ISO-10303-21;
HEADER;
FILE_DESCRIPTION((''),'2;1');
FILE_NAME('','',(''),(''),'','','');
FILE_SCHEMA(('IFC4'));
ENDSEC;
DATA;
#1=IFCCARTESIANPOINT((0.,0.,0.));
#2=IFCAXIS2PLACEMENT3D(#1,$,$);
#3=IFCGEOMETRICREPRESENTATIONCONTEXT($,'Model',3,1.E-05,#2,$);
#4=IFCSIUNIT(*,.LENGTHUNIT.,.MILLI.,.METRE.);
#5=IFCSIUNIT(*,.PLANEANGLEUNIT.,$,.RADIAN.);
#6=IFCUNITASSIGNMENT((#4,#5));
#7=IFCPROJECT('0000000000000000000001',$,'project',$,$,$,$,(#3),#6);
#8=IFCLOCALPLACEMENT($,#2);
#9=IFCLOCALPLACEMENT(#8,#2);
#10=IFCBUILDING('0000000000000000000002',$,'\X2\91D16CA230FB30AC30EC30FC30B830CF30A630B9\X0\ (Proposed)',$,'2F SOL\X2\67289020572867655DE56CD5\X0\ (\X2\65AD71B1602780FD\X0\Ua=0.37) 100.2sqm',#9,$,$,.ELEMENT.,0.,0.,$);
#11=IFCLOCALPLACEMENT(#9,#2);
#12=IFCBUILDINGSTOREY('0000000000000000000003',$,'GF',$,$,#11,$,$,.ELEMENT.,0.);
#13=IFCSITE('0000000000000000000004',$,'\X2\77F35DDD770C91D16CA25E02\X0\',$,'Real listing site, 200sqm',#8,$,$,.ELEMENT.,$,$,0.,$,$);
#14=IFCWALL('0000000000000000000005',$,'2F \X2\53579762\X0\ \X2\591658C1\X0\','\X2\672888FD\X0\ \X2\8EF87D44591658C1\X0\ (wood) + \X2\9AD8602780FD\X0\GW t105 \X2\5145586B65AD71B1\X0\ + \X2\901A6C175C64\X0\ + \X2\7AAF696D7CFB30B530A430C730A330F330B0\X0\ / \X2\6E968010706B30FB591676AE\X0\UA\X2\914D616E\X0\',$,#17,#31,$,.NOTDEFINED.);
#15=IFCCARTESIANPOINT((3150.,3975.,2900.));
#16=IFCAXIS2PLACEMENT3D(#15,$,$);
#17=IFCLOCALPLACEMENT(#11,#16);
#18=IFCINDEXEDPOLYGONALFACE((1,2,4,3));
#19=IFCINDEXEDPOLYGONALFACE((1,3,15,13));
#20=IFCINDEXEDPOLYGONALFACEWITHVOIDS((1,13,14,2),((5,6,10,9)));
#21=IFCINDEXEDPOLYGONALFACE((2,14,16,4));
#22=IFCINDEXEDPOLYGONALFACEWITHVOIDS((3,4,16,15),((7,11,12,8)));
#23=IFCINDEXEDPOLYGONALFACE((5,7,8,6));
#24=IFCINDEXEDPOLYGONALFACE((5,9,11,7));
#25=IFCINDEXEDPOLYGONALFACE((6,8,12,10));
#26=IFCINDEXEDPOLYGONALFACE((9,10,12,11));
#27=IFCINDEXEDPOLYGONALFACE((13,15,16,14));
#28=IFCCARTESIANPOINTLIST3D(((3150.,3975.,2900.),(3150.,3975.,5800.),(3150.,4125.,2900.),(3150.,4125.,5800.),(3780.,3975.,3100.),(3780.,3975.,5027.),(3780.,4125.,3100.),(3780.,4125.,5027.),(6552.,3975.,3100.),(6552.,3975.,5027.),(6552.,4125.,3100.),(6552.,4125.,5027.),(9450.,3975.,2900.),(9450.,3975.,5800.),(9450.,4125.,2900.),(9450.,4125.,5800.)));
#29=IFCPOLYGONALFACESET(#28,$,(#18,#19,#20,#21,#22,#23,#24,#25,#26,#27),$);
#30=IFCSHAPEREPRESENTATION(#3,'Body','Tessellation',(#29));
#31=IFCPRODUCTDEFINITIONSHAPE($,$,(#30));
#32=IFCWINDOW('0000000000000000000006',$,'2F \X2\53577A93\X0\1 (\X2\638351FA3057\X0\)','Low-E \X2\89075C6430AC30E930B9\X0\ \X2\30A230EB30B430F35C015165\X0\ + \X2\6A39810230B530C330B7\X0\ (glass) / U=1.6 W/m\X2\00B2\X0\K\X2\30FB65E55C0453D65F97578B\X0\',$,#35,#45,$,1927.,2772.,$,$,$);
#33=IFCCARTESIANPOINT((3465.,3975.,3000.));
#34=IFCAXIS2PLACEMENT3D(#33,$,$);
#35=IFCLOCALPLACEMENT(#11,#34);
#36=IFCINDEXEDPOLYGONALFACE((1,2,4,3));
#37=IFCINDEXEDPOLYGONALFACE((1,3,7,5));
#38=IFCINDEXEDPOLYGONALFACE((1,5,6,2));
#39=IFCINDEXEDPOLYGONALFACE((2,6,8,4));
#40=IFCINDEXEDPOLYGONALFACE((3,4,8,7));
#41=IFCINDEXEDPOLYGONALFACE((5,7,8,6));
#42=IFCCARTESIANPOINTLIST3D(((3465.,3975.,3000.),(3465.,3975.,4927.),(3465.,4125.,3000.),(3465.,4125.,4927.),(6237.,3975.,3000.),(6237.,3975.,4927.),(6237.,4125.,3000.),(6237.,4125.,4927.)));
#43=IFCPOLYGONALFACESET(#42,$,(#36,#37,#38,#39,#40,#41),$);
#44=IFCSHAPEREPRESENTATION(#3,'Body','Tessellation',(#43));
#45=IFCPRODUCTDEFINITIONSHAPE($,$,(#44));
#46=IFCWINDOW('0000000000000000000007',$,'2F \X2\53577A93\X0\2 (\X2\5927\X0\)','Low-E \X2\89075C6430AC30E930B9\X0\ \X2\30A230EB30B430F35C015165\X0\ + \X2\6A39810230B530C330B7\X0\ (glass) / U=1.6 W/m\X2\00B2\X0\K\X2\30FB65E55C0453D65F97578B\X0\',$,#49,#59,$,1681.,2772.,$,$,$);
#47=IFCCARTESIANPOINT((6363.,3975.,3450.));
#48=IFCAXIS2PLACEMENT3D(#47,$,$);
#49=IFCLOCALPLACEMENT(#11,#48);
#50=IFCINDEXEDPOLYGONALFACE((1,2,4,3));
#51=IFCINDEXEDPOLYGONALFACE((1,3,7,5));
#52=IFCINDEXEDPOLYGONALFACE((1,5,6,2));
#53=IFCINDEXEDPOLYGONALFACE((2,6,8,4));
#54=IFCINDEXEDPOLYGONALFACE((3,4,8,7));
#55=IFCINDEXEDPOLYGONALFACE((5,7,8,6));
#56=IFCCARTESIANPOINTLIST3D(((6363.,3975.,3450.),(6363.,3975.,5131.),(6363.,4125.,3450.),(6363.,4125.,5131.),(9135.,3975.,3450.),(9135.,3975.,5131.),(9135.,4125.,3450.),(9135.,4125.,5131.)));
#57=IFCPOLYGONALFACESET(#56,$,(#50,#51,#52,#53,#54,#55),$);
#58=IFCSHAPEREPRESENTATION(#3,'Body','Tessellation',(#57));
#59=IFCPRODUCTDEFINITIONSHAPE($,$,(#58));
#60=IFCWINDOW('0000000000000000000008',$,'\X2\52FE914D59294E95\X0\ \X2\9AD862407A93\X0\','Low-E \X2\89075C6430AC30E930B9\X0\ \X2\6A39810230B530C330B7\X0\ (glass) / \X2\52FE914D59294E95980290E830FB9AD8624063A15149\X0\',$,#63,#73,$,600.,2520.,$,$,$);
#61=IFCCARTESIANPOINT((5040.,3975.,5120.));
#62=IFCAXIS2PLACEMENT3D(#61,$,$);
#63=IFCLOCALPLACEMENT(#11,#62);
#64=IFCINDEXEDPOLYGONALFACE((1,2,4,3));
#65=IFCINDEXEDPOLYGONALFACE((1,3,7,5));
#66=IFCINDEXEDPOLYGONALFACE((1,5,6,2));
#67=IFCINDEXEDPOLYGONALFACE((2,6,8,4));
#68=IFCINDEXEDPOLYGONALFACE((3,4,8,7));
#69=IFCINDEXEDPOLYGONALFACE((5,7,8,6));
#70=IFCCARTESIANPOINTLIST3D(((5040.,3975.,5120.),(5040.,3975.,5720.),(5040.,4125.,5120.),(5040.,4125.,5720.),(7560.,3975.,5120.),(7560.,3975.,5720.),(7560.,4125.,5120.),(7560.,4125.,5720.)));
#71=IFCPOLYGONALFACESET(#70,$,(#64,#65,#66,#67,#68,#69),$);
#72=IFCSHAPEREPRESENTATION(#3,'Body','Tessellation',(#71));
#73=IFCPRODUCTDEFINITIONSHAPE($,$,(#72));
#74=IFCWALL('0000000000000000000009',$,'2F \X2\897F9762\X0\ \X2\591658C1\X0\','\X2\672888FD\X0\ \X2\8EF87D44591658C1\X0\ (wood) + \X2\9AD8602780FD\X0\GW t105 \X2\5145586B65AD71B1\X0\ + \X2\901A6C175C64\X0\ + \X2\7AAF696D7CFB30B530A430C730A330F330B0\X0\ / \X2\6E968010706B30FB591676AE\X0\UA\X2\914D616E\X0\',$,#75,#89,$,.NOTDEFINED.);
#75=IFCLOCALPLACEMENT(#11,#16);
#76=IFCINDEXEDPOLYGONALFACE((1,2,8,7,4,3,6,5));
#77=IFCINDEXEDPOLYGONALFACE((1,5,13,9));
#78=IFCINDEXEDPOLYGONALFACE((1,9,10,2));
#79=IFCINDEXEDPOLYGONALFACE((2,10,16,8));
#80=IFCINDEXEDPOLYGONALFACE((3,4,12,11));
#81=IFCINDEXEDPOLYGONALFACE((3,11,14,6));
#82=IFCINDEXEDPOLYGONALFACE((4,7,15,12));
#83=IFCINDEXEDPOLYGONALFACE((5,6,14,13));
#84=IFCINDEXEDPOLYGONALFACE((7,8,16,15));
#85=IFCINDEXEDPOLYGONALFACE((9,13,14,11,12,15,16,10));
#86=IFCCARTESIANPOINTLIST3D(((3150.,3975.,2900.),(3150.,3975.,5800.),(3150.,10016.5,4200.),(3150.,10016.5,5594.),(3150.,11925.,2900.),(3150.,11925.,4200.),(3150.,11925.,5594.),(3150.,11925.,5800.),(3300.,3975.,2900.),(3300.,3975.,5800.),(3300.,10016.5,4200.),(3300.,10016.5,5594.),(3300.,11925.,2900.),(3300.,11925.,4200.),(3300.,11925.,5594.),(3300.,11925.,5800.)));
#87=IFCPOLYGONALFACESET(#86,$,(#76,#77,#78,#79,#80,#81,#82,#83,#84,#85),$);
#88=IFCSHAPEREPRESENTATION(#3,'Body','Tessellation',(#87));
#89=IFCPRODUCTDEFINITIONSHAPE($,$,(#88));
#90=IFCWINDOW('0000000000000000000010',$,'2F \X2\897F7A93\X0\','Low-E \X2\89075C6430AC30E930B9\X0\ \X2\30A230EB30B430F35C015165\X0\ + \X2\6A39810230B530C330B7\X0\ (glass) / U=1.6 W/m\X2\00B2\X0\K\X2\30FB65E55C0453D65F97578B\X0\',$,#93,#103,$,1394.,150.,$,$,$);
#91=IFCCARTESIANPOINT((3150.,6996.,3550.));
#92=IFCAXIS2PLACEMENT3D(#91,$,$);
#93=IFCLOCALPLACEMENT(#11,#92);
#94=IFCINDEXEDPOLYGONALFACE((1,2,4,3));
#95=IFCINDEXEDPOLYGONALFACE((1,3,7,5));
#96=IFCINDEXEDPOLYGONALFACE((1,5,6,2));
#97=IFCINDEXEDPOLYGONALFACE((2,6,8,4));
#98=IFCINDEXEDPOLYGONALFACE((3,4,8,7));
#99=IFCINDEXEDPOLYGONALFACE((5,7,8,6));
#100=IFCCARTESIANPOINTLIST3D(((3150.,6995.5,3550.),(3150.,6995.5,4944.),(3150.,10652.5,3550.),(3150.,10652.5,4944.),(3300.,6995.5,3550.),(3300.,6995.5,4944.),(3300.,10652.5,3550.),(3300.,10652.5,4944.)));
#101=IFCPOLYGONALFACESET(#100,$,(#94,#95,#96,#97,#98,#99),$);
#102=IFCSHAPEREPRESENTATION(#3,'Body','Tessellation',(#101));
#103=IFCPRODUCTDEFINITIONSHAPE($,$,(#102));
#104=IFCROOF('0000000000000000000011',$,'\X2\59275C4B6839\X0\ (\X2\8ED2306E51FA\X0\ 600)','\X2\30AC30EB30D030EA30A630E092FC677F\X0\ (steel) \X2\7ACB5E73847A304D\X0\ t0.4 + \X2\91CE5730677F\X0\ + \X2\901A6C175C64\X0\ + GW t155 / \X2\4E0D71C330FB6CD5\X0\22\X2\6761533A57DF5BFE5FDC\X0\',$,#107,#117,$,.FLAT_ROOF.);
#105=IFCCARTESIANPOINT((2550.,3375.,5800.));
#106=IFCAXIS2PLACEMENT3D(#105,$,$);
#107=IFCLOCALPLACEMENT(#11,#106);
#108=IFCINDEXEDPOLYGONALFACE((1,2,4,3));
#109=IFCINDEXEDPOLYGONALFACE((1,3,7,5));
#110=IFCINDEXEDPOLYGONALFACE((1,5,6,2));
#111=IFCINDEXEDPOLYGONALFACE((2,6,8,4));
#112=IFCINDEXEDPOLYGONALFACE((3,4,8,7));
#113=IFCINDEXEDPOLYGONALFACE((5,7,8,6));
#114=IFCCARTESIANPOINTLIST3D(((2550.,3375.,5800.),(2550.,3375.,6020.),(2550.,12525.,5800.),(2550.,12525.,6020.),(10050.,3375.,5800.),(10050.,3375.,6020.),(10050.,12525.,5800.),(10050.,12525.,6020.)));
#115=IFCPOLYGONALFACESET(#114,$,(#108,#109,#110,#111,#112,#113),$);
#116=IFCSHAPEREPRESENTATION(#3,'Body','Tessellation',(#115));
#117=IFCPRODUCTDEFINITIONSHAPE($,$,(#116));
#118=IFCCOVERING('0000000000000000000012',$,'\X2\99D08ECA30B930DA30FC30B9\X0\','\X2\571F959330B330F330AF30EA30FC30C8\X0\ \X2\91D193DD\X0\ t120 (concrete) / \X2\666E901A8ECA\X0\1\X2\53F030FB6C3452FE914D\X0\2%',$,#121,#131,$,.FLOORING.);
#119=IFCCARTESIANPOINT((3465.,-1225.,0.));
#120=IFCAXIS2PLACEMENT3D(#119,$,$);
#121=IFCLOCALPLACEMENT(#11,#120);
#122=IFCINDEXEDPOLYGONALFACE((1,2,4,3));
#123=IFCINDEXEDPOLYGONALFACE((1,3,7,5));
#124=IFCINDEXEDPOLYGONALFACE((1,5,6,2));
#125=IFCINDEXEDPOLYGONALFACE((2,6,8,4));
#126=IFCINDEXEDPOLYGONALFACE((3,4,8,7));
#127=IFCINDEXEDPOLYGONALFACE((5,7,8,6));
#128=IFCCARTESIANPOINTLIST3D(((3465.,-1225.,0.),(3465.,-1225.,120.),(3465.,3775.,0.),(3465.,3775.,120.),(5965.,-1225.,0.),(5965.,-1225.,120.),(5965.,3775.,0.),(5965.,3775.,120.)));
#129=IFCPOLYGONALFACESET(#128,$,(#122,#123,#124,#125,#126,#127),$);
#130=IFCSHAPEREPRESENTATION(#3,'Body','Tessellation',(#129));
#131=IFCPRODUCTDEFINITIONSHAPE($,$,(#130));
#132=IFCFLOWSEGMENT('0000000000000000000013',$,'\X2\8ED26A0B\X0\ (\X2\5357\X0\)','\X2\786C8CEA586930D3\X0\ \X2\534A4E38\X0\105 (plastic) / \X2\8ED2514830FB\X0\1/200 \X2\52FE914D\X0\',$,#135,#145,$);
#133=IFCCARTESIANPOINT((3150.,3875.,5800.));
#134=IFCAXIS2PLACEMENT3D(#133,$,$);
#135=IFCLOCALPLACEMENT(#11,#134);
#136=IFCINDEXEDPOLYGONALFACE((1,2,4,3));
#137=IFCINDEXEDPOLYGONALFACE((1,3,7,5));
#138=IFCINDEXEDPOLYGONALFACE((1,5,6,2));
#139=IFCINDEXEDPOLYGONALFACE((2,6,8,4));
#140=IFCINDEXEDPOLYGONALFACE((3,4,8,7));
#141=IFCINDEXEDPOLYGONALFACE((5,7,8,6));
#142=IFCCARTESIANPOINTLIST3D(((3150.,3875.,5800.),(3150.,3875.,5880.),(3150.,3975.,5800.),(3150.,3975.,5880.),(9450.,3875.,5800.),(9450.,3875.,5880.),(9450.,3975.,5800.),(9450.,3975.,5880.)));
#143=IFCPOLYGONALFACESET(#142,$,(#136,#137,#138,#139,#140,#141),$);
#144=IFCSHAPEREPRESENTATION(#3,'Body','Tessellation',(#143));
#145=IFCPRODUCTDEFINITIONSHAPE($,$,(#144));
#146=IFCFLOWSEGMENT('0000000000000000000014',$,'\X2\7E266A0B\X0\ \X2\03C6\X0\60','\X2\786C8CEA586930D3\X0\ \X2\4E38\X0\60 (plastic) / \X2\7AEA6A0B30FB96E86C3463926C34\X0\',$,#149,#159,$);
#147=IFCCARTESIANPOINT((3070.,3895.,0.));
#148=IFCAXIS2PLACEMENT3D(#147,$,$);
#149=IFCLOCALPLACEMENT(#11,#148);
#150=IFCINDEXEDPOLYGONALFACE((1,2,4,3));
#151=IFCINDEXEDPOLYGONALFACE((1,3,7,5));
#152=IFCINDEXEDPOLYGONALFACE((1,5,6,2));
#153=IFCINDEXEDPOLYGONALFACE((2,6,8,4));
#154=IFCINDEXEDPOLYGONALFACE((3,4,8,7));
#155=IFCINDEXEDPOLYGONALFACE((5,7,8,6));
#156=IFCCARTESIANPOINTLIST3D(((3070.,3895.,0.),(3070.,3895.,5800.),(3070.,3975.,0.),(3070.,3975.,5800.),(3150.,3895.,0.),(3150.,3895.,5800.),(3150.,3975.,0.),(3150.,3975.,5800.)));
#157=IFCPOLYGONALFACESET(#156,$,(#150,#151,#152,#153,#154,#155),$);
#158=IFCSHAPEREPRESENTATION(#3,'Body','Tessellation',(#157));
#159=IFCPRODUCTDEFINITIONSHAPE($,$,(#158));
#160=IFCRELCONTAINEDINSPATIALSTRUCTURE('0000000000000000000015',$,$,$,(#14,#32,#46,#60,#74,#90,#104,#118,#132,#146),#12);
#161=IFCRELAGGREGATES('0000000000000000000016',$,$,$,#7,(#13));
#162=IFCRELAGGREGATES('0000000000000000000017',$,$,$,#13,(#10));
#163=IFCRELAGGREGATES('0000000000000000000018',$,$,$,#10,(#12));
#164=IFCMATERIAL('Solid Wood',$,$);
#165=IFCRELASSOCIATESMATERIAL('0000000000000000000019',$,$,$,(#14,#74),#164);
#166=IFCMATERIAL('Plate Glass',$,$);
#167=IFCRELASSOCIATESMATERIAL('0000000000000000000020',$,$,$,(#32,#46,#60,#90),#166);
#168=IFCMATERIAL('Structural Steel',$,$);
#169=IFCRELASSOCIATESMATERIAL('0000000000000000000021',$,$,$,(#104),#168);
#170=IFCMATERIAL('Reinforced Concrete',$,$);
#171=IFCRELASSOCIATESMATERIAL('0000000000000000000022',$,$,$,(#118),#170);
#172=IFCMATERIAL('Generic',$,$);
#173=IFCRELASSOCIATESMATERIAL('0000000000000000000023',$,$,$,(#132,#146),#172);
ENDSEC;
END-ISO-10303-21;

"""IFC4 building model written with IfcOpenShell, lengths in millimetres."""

from ifc_helpers import new_model, si_unit, frame, frame_2d, origin, place, context, project, spatial, rectangle, extrude, material, element, fill, save


model = new_model("IFC4")

# Units and contexts
model_context = context("Model", 3, precision=1e-05, world=origin())
ifc_project = project(units=[si_unit("LENGTHUNIT", "METRE", prefix="MILLI"), si_unit("PLANEANGLEUNIT", "RADIAN")], contexts=[model_context])

# Site, building, storey
site_placement = place(None, origin())
site = spatial("IfcSite", under=ifc_project, at=site_placement, Name="石川県金沢市", ObjectType="Real listing site, 200sqm", CompositionType="ELEMENT", RefElevation=0.0)
building_placement = place(site_placement, origin())
building = spatial("IfcBuilding", under=site, at=building_placement, Name="金沢・ガレージハウス (Proposed)", ObjectType="2F SOL木造在来工法 (断熱性能Ua=0.37) 100.2sqm", CompositionType="ELEMENT", ElevationOfRefHeight=0.0, ElevationOfTerrain=0.0)
storey_placement = place(building_placement, origin())
storey = spatial("IfcBuildingStorey", under=building, at=storey_placement, Name="GF", CompositionType="ELEMENT", Elevation=0.0)

# Shared definitions
ifc_material_1 = material(Name="Solid Wood")

# Shared definitions
ifc_material_2 = material(Name="Reinforced Concrete")

# Shared definitions
ifc_material_3 = material(Name="Plate Glass")

# Wall, openings, windows
wall_1_placement = place(storey_placement, frame((3150.0, 3975.0, 2900.0)))
wall_1 = element("IfcWall", 1, at=wall_1_placement, inside=storey, material=ifc_material_1, Name="2F 南面 外壁", Description="木製 軸組外壁 (wood) + 高性能GW t105 充填断熱 + 通気層 + 窯業系サイディング / 準耐火・外皮UA配慮", PredefinedType="NOTDEFINED", context=model_context, shape_type="SweptSolid", body=[
    extrude(rectangle(XDim=6300.0, YDim=150.0, at=frame_2d((3150.0, 75.0))), frame((3150.0, 3975.0, 2900.0)), (0.0, 0.0, 1.0), 2900.0),
])
opening_1_placement = place(storey_placement, frame((3465.0, 3975.0, 3000.0)))
opening_1 = element("IfcOpeningElement", 2, at=opening_1_placement, cuts=wall_1, PredefinedType="NOTDEFINED", context=model_context, shape_type="SweptSolid", body=[
    extrude(rectangle(XDim=2772.0, YDim=150.0, at=frame_2d((1386.0, 75.0))), frame((3465.0, 3975.0, 3000.0)), (0.0, 0.0, 1.0), 1927.0),
])
opening_2_placement = place(storey_placement, frame((6363.0, 3975.0, 3450.0)))
opening_2 = element("IfcOpeningElement", 3, at=opening_2_placement, cuts=wall_1, PredefinedType="NOTDEFINED", context=model_context, shape_type="SweptSolid", body=[
    extrude(rectangle(XDim=2772.0, YDim=150.0, at=frame_2d((1386.0, 75.0))), frame((6363.0, 3975.0, 3450.0)), (0.0, 0.0, 1.0), 1681.0),
])
opening_3_placement = place(storey_placement, frame((5040.0, 3975.0, 5120.0)))
opening_3 = element("IfcOpeningElement", 4, at=opening_3_placement, cuts=wall_1, PredefinedType="NOTDEFINED", context=model_context, shape_type="SweptSolid", body=[
    extrude(rectangle(XDim=2520.0, YDim=150.0, at=frame_2d((1260.0, 75.0))), frame((5040.0, 3975.0, 5120.0)), (0.0, 0.0, 1.0), 600.0),
])
window_1_placement = place(storey_placement, frame((3465.0, 3975.0, 3000.0)))
window_1 = element("IfcWindow", 5, at=window_1_placement, inside=storey, material=ifc_material_3, Name="2F 南窓1 (掃出し)", Description="Low-E 複層ガラス アルゴン封入 + 樹脂サッシ (glass) / U=1.6 W/m²K・日射取得型", OverallHeight=1927.0, OverallWidth=2772.0, context=model_context, shape_type="SweptSolid", body=[
    extrude(rectangle(XDim=2772.0, YDim=150.0, at=frame_2d((1386.0, 75.0))), frame((3465.0, 3975.0, 3000.0)), (0.0, 0.0, 1.0), 1927.0),
])
fill(opening_1, window_1)
window_2_placement = place(storey_placement, frame((6363.0, 3975.0, 3450.0)))
window_2 = element("IfcWindow", 6, at=window_2_placement, inside=storey, material=ifc_material_3, Name="2F 南窓2 (大)", Description="Low-E 複層ガラス アルゴン封入 + 樹脂サッシ (glass) / U=1.6 W/m²K・日射取得型", OverallHeight=1681.0, OverallWidth=2772.0, context=model_context, shape_type="SweptSolid", body=[
    extrude(rectangle(XDim=2772.0, YDim=150.0, at=frame_2d((1386.0, 75.0))), frame((6363.0, 3975.0, 3450.0)), (0.0, 0.0, 1.0), 1681.0),
])
fill(opening_2, window_2)
window_3_placement = place(storey_placement, frame((5040.0, 3975.0, 5120.0)))
window_3 = element("IfcWindow", 7, at=window_3_placement, inside=storey, material=ifc_material_3, Name="勾配天井 高所窓", Description="Low-E 複層ガラス 樹脂サッシ (glass) / 勾配天井頂部・高所採光", OverallHeight=600.0, OverallWidth=2520.0, context=model_context, shape_type="SweptSolid", body=[
    extrude(rectangle(XDim=2520.0, YDim=150.0, at=frame_2d((1260.0, 75.0))), frame((5040.0, 3975.0, 5120.0)), (0.0, 0.0, 1.0), 600.0),
])
fill(opening_3, window_3)

# Wall, opening, window
wall_2_placement = place(storey_placement, frame((3150.0, 3975.0, 2900.0)))
wall_2 = element("IfcWall", 8, at=wall_2_placement, inside=storey, material=ifc_material_1, Name="2F 西面 外壁", Description="木製 軸組外壁 (wood) + 高性能GW t105 充填断熱 + 通気層 + 窯業系サイディング / 準耐火・外皮UA配慮", PredefinedType="NOTDEFINED", context=model_context, shape_type="SweptSolid", body=[
    extrude(rectangle(XDim=150.0, YDim=7950.0, at=frame_2d((75.0, 3975.0))), frame((3150.0, 3975.0, 2900.0)), (0.0, 0.0, 1.0), 2900.0),
])
opening_4_placement = place(storey_placement, frame((3150.0, 6996.0, 3550.0)))
opening_4 = element("IfcOpeningElement", 9, at=opening_4_placement, cuts=wall_2, PredefinedType="NOTDEFINED", context=model_context, shape_type="SweptSolid", body=[
    extrude(rectangle(XDim=150.0, YDim=3657.0, at=frame_2d((75.0, 1828.0))), frame((3150.0, 6996.0, 3550.0)), (0.0, 0.0, 1.0), 1394.0),
])
window_4_placement = place(storey_placement, frame((3150.0, 6996.0, 3550.0)))
window_4 = element("IfcWindow", 10, at=window_4_placement, inside=storey, material=ifc_material_3, Name="2F 西窓", Description="Low-E 複層ガラス アルゴン封入 + 樹脂サッシ (glass) / U=1.6 W/m²K・日射取得型", OverallHeight=1394.0, OverallWidth=150.0, context=model_context, shape_type="SweptSolid", body=[
    extrude(rectangle(XDim=150.0, YDim=3657.0, at=frame_2d((75.0, 1828.0))), frame((3150.0, 6996.0, 3550.0)), (0.0, 0.0, 1.0), 1394.0),
])
fill(opening_4, window_4)

# Roof
ifc_material_4 = material(Name="Structural Steel")
roof_placement = place(storey_placement, frame((2550.0, 3375.0, 5800.0)))
element("IfcRoof", 11, at=roof_placement, inside=storey, material=ifc_material_4, Name="大屋根 (軒の出 600)", Description="ガルバリウム鋼板 (steel) 立平葺き t0.4 + 野地板 + 通気層 + GW t155 / 不燃・法22条区域対応", PredefinedType="FLAT_ROOF", context=model_context, shape_type="SweptSolid", body=[
    extrude(rectangle(XDim=7500.0, YDim=9150.0, at=frame_2d((3750.0, 4575.0))), frame((2550.0, 3375.0, 5800.0)), (0.0, 0.0, 1.0), 220.0),
])

# Covering
covering_placement = place(storey_placement, frame((3465.0, -1225.0, 0.0)))
element("IfcCovering", 12, at=covering_placement, inside=storey, material=ifc_material_2, Name="駐車スペース", Description="土間コンクリート 金鏝 t120 (concrete) / 普通車1台・水勾配2%", PredefinedType="FLOORING", context=model_context, shape_type="SweptSolid", body=[
    extrude(rectangle(XDim=2500.0, YDim=5000.0, at=frame_2d((1250.0, 2500.0))), frame((3465.0, -1225.0, 0.0)), (0.0, 0.0, 1.0), 120.0),
])

# Flow segments
ifc_material_5 = material(Name="Generic")
flow_segment_1_placement = place(storey_placement, frame((3150.0, 3875.0, 5800.0)))
element("IfcFlowSegment", 13, at=flow_segment_1_placement, inside=storey, material=ifc_material_5, Name="軒樋 (南)", Description="硬質塩ビ 半丸105 (plastic) / 軒先・1/200 勾配", context=model_context, shape_type="SweptSolid", body=[
    extrude(rectangle(XDim=6300.0, YDim=100.0, at=frame_2d((3150.0, 50.0))), frame((3150.0, 3875.0, 5800.0)), (0.0, 0.0, 1.0), 80.0),
])
flow_segment_2_placement = place(storey_placement, frame((3070.0, 3895.0, 0.0)))
element("IfcFlowSegment", 14, at=flow_segment_2_placement, inside=storey, material=ifc_material_5, Name="縦樋 φ60", Description="硬質塩ビ 丸60 (plastic) / 竪樋・雨水排水", context=model_context, shape_type="SweptSolid", body=[
    extrude(rectangle(XDim=80.0, YDim=80.0, at=frame_2d((40.0, 40.0))), frame((3070.0, 3895.0, 0.0)), (0.0, 0.0, 1.0), 5800.0),
])

save(model, "model.ifc")
